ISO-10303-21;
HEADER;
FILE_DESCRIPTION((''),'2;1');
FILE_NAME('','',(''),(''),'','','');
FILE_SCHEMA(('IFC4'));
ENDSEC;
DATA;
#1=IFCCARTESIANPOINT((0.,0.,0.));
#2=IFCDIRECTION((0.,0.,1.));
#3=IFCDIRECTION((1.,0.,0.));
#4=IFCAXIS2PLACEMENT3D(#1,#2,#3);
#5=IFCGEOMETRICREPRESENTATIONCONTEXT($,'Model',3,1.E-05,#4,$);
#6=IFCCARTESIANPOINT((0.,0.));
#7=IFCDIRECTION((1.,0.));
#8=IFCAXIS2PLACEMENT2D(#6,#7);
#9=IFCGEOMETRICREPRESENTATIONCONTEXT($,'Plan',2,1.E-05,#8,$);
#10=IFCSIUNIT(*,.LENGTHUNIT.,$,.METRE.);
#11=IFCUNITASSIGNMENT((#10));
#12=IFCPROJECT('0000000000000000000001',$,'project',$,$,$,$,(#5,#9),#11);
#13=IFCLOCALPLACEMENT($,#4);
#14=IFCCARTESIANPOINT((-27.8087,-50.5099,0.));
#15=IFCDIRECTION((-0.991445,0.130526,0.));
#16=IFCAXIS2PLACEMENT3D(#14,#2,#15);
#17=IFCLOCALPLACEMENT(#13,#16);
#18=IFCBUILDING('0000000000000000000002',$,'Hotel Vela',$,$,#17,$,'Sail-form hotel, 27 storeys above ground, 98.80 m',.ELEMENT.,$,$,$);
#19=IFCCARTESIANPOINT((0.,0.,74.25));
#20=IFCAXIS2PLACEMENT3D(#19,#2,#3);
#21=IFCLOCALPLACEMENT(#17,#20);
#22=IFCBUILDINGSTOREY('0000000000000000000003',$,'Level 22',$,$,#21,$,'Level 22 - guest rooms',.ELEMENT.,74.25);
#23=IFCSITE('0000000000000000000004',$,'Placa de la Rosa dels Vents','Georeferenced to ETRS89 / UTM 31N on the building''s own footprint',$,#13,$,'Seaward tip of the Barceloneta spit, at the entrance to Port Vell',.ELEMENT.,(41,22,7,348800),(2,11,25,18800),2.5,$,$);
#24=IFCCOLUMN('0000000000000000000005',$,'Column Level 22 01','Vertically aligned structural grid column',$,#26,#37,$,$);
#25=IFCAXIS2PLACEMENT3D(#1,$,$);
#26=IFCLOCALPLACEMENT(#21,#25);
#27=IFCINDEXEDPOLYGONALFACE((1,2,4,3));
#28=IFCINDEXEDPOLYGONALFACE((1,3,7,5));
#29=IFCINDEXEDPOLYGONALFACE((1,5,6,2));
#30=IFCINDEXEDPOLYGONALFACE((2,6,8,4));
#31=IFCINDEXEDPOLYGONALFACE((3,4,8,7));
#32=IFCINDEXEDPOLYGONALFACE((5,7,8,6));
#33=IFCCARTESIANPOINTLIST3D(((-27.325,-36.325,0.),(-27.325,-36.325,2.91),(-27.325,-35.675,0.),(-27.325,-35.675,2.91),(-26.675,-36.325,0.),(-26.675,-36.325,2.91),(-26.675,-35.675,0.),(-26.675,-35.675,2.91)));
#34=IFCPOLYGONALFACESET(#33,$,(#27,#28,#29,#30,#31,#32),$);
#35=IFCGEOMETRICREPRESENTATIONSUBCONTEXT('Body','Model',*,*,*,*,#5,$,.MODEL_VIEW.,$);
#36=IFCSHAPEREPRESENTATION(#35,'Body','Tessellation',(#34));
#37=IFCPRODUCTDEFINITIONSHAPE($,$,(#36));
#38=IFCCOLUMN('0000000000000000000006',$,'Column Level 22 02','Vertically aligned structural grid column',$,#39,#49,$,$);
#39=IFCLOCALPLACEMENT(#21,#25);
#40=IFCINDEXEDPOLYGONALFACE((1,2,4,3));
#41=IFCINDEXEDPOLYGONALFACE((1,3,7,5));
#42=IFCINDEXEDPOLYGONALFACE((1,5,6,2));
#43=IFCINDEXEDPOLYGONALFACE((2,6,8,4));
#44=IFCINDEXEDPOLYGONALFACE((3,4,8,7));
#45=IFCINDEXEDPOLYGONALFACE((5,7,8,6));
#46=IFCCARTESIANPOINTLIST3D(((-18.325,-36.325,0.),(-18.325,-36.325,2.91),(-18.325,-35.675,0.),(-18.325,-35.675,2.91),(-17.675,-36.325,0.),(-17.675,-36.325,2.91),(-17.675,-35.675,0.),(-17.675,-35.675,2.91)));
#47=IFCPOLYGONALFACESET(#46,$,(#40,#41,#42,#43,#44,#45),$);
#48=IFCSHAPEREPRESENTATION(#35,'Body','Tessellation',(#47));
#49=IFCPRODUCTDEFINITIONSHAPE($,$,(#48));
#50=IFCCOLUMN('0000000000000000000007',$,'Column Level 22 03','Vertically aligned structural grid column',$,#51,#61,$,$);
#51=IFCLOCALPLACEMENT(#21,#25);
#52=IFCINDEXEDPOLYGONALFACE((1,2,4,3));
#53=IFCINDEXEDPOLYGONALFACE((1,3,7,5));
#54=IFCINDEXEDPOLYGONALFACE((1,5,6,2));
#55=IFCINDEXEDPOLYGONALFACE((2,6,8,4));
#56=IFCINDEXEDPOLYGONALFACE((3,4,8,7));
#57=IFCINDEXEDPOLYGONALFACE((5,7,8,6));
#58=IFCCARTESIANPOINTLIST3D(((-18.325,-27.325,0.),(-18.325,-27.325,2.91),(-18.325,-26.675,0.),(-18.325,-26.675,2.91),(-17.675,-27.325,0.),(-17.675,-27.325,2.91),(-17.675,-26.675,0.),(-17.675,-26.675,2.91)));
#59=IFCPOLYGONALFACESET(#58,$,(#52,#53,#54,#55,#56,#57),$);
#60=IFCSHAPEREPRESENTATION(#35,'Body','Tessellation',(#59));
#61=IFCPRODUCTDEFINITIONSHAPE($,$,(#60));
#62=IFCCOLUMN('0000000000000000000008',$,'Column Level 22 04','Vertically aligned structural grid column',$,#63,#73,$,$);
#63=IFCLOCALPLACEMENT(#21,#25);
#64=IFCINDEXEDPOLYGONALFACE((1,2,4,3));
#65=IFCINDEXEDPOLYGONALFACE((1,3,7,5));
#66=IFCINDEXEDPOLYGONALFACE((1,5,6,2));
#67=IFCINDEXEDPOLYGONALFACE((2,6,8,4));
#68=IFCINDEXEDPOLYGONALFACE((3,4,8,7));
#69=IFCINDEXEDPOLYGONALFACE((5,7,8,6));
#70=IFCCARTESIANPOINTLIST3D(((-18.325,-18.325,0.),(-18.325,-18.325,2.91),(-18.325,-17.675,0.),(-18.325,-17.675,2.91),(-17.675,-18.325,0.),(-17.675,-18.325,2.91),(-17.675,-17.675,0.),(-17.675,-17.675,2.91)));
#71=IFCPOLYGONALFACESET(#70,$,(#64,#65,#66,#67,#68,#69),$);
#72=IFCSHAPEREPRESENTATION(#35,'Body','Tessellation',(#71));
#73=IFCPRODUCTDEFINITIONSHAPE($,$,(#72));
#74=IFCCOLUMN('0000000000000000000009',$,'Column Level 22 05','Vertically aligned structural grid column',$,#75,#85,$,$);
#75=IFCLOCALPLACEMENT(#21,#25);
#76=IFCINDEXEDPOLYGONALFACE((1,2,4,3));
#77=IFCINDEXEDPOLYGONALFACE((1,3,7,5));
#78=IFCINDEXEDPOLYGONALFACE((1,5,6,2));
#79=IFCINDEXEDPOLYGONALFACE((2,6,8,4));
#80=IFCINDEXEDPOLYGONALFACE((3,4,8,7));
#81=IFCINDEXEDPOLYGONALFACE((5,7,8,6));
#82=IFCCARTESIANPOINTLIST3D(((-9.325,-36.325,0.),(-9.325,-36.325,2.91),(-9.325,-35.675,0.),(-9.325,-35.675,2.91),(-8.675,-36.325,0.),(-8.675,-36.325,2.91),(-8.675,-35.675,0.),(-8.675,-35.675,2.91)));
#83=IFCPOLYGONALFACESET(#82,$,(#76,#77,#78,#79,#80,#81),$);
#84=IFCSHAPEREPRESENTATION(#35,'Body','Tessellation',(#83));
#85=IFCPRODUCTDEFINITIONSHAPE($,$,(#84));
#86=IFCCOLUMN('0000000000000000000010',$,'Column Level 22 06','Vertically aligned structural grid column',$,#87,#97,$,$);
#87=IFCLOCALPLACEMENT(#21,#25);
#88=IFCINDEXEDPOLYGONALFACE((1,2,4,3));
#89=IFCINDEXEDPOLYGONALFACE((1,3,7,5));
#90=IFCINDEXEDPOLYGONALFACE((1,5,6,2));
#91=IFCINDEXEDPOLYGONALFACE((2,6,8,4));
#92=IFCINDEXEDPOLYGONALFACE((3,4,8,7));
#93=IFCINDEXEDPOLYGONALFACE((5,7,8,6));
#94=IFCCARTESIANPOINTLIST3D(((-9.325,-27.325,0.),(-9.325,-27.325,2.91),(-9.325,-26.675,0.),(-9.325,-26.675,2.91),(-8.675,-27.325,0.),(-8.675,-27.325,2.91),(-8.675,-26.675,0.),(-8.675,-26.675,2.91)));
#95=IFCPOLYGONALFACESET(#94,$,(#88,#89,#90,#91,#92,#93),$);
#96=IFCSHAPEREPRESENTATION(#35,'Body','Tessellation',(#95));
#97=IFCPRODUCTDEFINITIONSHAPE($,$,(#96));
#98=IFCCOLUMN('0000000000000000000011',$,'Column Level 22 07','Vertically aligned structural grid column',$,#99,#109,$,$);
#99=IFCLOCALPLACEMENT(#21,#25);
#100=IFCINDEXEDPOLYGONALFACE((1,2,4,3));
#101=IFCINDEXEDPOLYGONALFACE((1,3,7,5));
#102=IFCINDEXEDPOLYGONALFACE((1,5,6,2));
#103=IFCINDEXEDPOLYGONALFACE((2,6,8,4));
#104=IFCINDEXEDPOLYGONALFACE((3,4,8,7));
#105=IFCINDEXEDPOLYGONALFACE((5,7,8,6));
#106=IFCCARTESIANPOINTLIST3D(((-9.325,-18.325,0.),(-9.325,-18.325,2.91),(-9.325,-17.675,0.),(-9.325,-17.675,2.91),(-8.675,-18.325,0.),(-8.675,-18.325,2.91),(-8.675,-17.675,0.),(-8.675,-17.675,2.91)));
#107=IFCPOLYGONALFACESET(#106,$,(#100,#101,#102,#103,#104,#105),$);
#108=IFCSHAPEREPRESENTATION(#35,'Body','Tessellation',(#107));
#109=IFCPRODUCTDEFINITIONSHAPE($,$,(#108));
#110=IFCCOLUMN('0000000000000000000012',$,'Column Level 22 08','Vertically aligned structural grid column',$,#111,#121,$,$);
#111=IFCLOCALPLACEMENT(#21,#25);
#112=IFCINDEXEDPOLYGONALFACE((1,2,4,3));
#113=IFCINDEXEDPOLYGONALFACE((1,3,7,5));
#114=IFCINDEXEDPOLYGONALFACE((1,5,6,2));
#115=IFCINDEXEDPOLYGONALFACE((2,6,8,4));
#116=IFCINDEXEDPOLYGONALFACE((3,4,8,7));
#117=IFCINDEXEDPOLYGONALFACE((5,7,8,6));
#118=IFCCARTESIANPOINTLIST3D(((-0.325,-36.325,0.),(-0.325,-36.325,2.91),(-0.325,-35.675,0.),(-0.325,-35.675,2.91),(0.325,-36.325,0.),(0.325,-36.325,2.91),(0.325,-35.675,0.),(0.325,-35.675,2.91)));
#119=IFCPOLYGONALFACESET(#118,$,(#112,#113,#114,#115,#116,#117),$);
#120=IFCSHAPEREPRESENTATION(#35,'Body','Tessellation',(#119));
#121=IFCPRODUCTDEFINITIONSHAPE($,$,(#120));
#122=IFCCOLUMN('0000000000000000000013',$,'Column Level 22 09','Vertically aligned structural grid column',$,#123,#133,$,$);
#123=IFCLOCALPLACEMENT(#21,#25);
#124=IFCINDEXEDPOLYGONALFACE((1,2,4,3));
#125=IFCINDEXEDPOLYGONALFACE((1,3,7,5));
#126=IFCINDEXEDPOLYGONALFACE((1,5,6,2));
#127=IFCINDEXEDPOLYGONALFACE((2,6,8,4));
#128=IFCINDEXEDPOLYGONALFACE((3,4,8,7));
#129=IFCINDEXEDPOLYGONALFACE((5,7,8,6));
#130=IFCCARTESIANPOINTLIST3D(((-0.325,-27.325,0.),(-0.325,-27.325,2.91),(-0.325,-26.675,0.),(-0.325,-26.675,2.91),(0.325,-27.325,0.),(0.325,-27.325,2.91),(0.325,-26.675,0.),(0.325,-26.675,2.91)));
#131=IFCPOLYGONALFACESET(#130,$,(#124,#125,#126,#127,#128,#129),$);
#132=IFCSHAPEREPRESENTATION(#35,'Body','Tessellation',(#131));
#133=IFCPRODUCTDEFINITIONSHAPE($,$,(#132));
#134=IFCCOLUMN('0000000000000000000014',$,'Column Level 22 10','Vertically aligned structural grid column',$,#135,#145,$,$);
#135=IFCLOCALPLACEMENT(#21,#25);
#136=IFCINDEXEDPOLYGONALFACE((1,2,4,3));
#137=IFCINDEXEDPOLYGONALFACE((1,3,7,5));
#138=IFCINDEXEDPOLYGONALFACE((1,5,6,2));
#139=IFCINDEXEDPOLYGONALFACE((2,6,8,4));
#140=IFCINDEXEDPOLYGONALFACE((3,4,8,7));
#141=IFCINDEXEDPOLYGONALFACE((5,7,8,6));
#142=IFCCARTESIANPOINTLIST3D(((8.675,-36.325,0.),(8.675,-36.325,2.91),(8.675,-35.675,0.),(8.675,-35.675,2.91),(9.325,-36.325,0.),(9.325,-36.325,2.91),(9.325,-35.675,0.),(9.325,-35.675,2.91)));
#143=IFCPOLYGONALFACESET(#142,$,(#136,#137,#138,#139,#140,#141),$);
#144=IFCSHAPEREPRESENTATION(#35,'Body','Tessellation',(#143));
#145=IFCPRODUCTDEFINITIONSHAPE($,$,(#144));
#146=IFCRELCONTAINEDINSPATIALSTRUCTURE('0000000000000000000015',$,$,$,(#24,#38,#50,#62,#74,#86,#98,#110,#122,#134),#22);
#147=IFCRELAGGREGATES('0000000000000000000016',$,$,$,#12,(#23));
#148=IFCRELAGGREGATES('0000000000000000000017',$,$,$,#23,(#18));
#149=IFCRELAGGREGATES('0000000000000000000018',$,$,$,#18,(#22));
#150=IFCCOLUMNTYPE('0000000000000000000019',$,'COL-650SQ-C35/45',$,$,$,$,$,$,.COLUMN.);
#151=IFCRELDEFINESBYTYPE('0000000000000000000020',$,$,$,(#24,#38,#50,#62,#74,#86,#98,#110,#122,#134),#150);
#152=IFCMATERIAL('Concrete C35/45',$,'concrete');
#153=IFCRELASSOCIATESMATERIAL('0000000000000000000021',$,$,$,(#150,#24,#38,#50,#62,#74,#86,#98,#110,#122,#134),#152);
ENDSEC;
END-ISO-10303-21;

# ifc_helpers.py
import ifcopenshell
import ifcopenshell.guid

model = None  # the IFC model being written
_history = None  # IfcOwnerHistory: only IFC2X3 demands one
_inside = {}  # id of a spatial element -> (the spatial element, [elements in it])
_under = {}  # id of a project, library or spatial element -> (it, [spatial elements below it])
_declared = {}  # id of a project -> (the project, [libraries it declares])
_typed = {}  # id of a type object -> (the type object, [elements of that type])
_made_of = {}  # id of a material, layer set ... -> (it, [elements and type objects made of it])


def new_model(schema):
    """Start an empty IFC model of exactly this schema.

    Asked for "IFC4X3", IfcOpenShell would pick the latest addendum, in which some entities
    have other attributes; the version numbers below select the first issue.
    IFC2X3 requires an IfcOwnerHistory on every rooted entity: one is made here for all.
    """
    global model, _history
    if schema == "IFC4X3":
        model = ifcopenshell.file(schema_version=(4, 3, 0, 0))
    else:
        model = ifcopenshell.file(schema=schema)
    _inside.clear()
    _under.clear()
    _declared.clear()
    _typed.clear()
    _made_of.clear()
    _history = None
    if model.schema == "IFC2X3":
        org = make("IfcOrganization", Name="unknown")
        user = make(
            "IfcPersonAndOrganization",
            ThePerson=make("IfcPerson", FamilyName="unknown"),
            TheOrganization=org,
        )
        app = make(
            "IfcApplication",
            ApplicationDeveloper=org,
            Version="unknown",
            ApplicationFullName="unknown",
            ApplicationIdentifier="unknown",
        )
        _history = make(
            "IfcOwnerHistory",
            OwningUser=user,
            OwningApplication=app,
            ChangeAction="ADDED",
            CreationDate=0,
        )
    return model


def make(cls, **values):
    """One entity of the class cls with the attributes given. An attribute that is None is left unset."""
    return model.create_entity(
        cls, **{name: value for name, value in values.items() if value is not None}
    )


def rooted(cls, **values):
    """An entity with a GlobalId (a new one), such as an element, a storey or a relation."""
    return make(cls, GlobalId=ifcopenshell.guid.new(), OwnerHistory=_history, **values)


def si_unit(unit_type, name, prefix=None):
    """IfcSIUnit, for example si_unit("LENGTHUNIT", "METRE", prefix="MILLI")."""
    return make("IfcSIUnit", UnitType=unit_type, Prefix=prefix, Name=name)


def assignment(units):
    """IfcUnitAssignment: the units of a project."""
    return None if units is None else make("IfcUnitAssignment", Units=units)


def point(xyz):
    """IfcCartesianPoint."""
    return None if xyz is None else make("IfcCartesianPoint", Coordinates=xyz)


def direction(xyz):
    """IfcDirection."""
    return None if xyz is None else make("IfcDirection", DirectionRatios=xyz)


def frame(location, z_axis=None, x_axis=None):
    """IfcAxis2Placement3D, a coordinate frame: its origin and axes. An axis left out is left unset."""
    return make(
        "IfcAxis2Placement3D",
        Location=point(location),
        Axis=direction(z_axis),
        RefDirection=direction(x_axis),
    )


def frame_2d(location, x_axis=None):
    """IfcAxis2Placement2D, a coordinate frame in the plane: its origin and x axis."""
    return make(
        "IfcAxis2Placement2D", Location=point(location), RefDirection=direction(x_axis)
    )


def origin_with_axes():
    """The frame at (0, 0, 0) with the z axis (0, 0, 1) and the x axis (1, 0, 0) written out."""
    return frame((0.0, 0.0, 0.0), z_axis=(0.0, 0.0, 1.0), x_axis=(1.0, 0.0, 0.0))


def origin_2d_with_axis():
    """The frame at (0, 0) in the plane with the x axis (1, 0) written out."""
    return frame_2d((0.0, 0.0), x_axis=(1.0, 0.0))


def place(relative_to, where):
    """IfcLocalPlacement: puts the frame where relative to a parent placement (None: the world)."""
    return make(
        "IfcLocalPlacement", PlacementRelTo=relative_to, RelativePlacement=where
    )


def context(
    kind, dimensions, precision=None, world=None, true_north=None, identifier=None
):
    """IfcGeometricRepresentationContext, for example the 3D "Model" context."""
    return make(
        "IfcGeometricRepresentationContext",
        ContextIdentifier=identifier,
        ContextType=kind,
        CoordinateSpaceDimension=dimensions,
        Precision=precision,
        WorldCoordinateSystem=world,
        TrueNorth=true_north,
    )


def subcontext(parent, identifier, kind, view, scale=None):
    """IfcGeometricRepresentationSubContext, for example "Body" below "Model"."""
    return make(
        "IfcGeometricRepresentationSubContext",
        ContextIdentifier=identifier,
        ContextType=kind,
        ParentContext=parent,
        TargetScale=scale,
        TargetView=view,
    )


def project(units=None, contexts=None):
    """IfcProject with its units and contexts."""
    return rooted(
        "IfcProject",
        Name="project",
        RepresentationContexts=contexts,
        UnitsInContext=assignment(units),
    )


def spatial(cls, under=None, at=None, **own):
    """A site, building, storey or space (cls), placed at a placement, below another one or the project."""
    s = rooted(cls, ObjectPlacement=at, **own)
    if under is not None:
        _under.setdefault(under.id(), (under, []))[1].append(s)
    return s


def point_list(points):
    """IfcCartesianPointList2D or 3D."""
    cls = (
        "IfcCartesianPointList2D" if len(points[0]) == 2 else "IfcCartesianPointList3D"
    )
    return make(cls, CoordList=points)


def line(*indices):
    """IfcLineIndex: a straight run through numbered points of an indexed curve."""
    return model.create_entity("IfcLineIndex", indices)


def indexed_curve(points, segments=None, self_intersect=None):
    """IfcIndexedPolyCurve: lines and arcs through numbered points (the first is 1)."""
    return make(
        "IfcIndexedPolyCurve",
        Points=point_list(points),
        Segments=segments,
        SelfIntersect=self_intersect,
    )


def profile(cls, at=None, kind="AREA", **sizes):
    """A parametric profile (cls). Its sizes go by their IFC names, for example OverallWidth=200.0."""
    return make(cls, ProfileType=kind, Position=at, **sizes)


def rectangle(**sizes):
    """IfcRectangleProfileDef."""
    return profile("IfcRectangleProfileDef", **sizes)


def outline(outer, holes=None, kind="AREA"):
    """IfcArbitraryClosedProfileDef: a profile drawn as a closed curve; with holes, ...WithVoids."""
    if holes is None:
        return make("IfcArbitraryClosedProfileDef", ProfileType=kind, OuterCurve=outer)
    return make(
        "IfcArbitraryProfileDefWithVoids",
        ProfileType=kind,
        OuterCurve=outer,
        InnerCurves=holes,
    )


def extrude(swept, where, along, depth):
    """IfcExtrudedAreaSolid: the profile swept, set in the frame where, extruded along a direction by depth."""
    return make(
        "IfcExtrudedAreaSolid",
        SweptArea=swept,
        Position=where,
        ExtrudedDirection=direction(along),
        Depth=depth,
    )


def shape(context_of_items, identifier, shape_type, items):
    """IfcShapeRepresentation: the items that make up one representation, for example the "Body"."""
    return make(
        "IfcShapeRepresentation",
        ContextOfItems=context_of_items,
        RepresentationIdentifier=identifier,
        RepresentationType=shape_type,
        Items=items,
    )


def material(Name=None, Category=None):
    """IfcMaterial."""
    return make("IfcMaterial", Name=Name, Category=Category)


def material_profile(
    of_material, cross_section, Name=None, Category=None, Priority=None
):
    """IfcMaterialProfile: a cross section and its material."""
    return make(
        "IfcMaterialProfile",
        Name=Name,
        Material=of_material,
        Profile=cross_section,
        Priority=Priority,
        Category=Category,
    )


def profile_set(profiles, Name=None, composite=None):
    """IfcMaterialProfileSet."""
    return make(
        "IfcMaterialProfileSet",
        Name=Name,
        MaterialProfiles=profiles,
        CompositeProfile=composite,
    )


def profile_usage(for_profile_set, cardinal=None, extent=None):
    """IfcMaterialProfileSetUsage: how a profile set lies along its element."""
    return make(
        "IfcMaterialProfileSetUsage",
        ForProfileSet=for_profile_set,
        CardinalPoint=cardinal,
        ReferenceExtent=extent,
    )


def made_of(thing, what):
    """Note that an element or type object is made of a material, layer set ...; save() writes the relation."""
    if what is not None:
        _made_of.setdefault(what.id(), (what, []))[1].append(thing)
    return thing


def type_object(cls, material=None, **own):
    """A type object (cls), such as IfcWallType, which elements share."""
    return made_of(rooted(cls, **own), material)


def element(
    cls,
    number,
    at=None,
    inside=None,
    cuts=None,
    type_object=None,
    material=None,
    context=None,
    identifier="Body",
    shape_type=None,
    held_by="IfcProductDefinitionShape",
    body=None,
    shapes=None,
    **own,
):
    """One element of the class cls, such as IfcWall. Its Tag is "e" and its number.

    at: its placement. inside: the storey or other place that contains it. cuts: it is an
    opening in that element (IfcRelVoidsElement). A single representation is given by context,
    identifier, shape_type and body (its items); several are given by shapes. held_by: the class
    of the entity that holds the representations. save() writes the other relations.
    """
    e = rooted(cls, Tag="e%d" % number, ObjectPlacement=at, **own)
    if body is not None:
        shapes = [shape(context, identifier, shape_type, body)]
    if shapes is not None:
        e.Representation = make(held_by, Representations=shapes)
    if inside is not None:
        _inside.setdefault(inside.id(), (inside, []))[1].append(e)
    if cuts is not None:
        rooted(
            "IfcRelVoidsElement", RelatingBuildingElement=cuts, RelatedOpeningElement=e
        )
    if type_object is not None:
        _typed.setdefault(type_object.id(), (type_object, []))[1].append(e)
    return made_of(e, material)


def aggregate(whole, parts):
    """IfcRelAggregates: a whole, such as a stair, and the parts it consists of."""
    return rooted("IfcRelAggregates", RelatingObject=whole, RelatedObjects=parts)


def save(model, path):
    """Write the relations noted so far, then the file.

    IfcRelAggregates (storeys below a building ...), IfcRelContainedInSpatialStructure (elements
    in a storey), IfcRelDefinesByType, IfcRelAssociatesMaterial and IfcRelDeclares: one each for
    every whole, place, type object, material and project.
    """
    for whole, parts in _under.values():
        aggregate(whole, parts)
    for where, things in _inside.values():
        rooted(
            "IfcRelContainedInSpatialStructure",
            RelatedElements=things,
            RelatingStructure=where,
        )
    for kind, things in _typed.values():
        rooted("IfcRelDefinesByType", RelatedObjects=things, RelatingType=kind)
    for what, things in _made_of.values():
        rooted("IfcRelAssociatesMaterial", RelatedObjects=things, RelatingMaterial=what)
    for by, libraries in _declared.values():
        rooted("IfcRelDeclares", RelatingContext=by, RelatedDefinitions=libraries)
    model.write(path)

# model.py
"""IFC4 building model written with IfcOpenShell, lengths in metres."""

from ifc_helpers import new_model, si_unit, frame, origin_with_axes, origin_2d_with_axis, place, context, subcontext, project, spatial, line, indexed_curve, rectangle, outline, extrude, material, material_profile, profile_set, profile_usage, type_object, element, save


model = new_model("IFC4")

# Units and contexts
model_context = context("Model", 3, precision=1e-05, world=origin_with_axes())
plan_context = context("Plan", 2, precision=1e-05, world=origin_2d_with_axis())
body_context = subcontext(model_context, "Body", "Model", "MODEL_VIEW")
ifc_project = project(units=[si_unit("LENGTHUNIT", "METRE")], contexts=[model_context, plan_context])

# Site, building, storey
site_placement = place(None, origin_with_axes())
site = spatial("IfcSite", under=ifc_project, at=site_placement, Name="Placa de la Rosa dels Vents", Description="Georeferenced to ETRS89 / UTM 31N on the building's own footprint", LongName="Seaward tip of the Barceloneta spit, at the entrance to Port Vell", CompositionType="ELEMENT", RefLatitude=(41, 22, 7, 348800), RefLongitude=(2, 11, 25, 18800), RefElevation=2.5)
building_placement = place(site_placement, frame((-27.8087, -50.5099, 0.0), z_axis=(0.0, 0.0, 1.0), x_axis=(-0.991445, 0.130526, 0.0)))
building = spatial("IfcBuilding", under=site, at=building_placement, Name="Hotel Vela", LongName="Sail-form hotel, 27 storeys above ground, 98.80 m", CompositionType="ELEMENT")
storey_placement = place(building_placement, frame((0.0, 0.0, 74.25), z_axis=(0.0, 0.0, 1.0), x_axis=(1.0, 0.0, 0.0)))
storey = spatial("IfcBuildingStorey", under=building, at=storey_placement, Name="Level 22", LongName="Level 22 - guest rooms", CompositionType="ELEMENT", Elevation=74.25)

# Columns
ifc_material = material(Name="Concrete C35/45", Category="concrete")
ifc_material_profile = material_profile(ifc_material, rectangle(XDim=0.65, YDim=0.65))
ifc_profile_set = profile_set([ifc_material_profile], Name="COL-650SQ-C35/45")
ifc_profile_usage_1 = profile_usage(ifc_profile_set)
column_type = type_object("IfcColumnType", Name="COL-650SQ-C35/45", PredefinedType="COLUMN", material=ifc_profile_set)
column_1_placement = place(storey_placement, frame((-27.325, -36.325, 0.0), z_axis=(0.0, 0.0, 1.0), x_axis=(1.0, 0.0, 0.0)))
element("IfcColumn", 1, at=column_1_placement, inside=storey, type_object=column_type, material=ifc_profile_usage_1, Name="Column Level 22 01", Description="Vertically aligned structural grid column", context=body_context, shape_type="SweptSolid", body=[
    extrude(outline(indexed_curve([(0.0, 0.0), (0.65, 0.0), (0.65, 0.65), (0.0, 0.65)], segments=[line(1, 2, 3, 4, 1)])), origin_with_axes(), (0.0, 0.0, 1.0), 2.91),
])
ifc_profile_usage_2 = profile_usage(ifc_profile_set)
column_2_placement = place(storey_placement, frame((-18.325, -36.325, 0.0), z_axis=(0.0, 0.0, 1.0), x_axis=(1.0, 0.0, 0.0)))
element("IfcColumn", 2, at=column_2_placement, inside=storey, type_object=column_type, material=ifc_profile_usage_2, Name="Column Level 22 02", Description="Vertically aligned structural grid column", context=body_context, shape_type="SweptSolid", body=[
    extrude(outline(indexed_curve([(0.0, 0.0), (0.65, 0.0), (0.65, 0.65), (0.0, 0.65)], segments=[line(1, 2, 3, 4, 1)])), origin_with_axes(), (0.0, 0.0, 1.0), 2.91),
])
ifc_profile_usage_3 = profile_usage(ifc_profile_set)
column_3_placement = place(storey_placement, frame((-18.325, -27.325, 0.0), z_axis=(0.0, 0.0, 1.0), x_axis=(1.0, 0.0, 0.0)))
element("IfcColumn", 3, at=column_3_placement, inside=storey, type_object=column_type, material=ifc_profile_usage_3, Name="Column Level 22 03", Description="Vertically aligned structural grid column", context=body_context, shape_type="SweptSolid", body=[
    extrude(outline(indexed_curve([(0.0, 0.0), (0.65, 0.0), (0.65, 0.65), (0.0, 0.65)], segments=[line(1, 2, 3, 4, 1)])), origin_with_axes(), (0.0, 0.0, 1.0), 2.91),
])
ifc_profile_usage_4 = profile_usage(ifc_profile_set)
column_4_placement = place(storey_placement, frame((-18.325, -18.325, 0.0), z_axis=(0.0, 0.0, 1.0), x_axis=(1.0, 0.0, 0.0)))
element("IfcColumn", 4, at=column_4_placement, inside=storey, type_object=column_type, material=ifc_profile_usage_4, Name="Column Level 22 04", Description="Vertically aligned structural grid column", context=body_context, shape_type="SweptSolid", body=[
    extrude(outline(indexed_curve([(0.0, 0.0), (0.65, 0.0), (0.65, 0.65), (0.0, 0.65)], segments=[line(1, 2, 3, 4, 1)])), origin_with_axes(), (0.0, 0.0, 1.0), 2.91),
])
ifc_profile_usage_5 = profile_usage(ifc_profile_set)
column_5_placement = place(storey_placement, frame((-9.325, -36.325, 0.0), z_axis=(0.0, 0.0, 1.0), x_axis=(1.0, 0.0, 0.0)))
element("IfcColumn", 5, at=column_5_placement, inside=storey, type_object=column_type, material=ifc_profile_usage_5, Name="Column Level 22 05", Description="Vertically aligned structural grid column", context=body_context, shape_type="SweptSolid", body=[
    extrude(outline(indexed_curve([(0.0, 0.0), (0.65, 0.0), (0.65, 0.65), (0.0, 0.65)], segments=[line(1, 2, 3, 4, 1)])), origin_with_axes(), (0.0, 0.0, 1.0), 2.91),
])
ifc_profile_usage_6 = profile_usage(ifc_profile_set)
column_6_placement = place(storey_placement, frame((-9.325, -27.325, 0.0), z_axis=(0.0, 0.0, 1.0), x_axis=(1.0, 0.0, 0.0)))
element("IfcColumn", 6, at=column_6_placement, inside=storey, type_object=column_type, material=ifc_profile_usage_6, Name="Column Level 22 06", Description="Vertically aligned structural grid column", context=body_context, shape_type="SweptSolid", body=[
    extrude(outline(indexed_curve([(0.0, 0.0), (0.65, 0.0), (0.65, 0.65), (0.0, 0.65)], segments=[line(1, 2, 3, 4, 1)])), origin_with_axes(), (0.0, 0.0, 1.0), 2.91),
])
ifc_profile_usage_7 = profile_usage(ifc_profile_set)
column_7_placement = place(storey_placement, frame((-9.325, -18.325, 0.0), z_axis=(0.0, 0.0, 1.0), x_axis=(1.0, 0.0, 0.0)))
element("IfcColumn", 7, at=column_7_placement, inside=storey, type_object=column_type, material=ifc_profile_usage_7, Name="Column Level 22 07", Description="Vertically aligned structural grid column", context=body_context, shape_type="SweptSolid", body=[
    extrude(outline(indexed_curve([(0.0, 0.0), (0.65, 0.0), (0.65, 0.65), (0.0, 0.65)], segments=[line(1, 2, 3, 4, 1)])), origin_with_axes(), (0.0, 0.0, 1.0), 2.91),
])
ifc_profile_usage_8 = profile_usage(ifc_profile_set)
column_8_placement = place(storey_placement, frame((-0.325, -36.325, 0.0), z_axis=(0.0, 0.0, 1.0), x_axis=(1.0, 0.0, 0.0)))
element("IfcColumn", 8, at=column_8_placement, inside=storey, type_object=column_type, material=ifc_profile_usage_8, Name="Column Level 22 08", Description="Vertically aligned structural grid column", context=body_context, shape_type="SweptSolid", body=[
    extrude(outline(indexed_curve([(0.0, 0.0), (0.65, 0.0), (0.65, 0.65), (0.0, 0.65)], segments=[line(1, 2, 3, 4, 1)])), origin_with_axes(), (0.0, 0.0, 1.0), 2.91),
])
ifc_profile_usage_9 = profile_usage(ifc_profile_set)
column_9_placement = place(storey_placement, frame((-0.325, -27.325, 0.0), z_axis=(0.0, 0.0, 1.0), x_axis=(1.0, 0.0, 0.0)))
element("IfcColumn", 9, at=column_9_placement, inside=storey, type_object=column_type, material=ifc_profile_usage_9, Name="Column Level 22 09", Description="Vertically aligned structural grid column", context=body_context, shape_type="SweptSolid", body=[
    extrude(outline(indexed_curve([(0.0, 0.0), (0.65, 0.0), (0.65, 0.65), (0.0, 0.65)], segments=[line(1, 2, 3, 4, 1)])), origin_with_axes(), (0.0, 0.0, 1.0), 2.91),
])
ifc_profile_usage_10 = profile_usage(ifc_profile_set)
column_10_placement = place(storey_placement, frame((8.675, -36.325, 0.0), z_axis=(0.0, 0.0, 1.0), x_axis=(1.0, 0.0, 0.0)))
element("IfcColumn", 10, at=column_10_placement, inside=storey, type_object=column_type, material=ifc_profile_usage_10, Name="Column Level 22 10", Description="Vertically aligned structural grid column", context=body_context, shape_type="SweptSolid", body=[
    extrude(outline(indexed_curve([(0.0, 0.0), (0.65, 0.0), (0.65, 0.65), (0.0, 0.65)], segments=[line(1, 2, 3, 4, 1)])), origin_with_axes(), (0.0, 0.0, 1.0), 2.91),
])

save(model, "model.ifc")
